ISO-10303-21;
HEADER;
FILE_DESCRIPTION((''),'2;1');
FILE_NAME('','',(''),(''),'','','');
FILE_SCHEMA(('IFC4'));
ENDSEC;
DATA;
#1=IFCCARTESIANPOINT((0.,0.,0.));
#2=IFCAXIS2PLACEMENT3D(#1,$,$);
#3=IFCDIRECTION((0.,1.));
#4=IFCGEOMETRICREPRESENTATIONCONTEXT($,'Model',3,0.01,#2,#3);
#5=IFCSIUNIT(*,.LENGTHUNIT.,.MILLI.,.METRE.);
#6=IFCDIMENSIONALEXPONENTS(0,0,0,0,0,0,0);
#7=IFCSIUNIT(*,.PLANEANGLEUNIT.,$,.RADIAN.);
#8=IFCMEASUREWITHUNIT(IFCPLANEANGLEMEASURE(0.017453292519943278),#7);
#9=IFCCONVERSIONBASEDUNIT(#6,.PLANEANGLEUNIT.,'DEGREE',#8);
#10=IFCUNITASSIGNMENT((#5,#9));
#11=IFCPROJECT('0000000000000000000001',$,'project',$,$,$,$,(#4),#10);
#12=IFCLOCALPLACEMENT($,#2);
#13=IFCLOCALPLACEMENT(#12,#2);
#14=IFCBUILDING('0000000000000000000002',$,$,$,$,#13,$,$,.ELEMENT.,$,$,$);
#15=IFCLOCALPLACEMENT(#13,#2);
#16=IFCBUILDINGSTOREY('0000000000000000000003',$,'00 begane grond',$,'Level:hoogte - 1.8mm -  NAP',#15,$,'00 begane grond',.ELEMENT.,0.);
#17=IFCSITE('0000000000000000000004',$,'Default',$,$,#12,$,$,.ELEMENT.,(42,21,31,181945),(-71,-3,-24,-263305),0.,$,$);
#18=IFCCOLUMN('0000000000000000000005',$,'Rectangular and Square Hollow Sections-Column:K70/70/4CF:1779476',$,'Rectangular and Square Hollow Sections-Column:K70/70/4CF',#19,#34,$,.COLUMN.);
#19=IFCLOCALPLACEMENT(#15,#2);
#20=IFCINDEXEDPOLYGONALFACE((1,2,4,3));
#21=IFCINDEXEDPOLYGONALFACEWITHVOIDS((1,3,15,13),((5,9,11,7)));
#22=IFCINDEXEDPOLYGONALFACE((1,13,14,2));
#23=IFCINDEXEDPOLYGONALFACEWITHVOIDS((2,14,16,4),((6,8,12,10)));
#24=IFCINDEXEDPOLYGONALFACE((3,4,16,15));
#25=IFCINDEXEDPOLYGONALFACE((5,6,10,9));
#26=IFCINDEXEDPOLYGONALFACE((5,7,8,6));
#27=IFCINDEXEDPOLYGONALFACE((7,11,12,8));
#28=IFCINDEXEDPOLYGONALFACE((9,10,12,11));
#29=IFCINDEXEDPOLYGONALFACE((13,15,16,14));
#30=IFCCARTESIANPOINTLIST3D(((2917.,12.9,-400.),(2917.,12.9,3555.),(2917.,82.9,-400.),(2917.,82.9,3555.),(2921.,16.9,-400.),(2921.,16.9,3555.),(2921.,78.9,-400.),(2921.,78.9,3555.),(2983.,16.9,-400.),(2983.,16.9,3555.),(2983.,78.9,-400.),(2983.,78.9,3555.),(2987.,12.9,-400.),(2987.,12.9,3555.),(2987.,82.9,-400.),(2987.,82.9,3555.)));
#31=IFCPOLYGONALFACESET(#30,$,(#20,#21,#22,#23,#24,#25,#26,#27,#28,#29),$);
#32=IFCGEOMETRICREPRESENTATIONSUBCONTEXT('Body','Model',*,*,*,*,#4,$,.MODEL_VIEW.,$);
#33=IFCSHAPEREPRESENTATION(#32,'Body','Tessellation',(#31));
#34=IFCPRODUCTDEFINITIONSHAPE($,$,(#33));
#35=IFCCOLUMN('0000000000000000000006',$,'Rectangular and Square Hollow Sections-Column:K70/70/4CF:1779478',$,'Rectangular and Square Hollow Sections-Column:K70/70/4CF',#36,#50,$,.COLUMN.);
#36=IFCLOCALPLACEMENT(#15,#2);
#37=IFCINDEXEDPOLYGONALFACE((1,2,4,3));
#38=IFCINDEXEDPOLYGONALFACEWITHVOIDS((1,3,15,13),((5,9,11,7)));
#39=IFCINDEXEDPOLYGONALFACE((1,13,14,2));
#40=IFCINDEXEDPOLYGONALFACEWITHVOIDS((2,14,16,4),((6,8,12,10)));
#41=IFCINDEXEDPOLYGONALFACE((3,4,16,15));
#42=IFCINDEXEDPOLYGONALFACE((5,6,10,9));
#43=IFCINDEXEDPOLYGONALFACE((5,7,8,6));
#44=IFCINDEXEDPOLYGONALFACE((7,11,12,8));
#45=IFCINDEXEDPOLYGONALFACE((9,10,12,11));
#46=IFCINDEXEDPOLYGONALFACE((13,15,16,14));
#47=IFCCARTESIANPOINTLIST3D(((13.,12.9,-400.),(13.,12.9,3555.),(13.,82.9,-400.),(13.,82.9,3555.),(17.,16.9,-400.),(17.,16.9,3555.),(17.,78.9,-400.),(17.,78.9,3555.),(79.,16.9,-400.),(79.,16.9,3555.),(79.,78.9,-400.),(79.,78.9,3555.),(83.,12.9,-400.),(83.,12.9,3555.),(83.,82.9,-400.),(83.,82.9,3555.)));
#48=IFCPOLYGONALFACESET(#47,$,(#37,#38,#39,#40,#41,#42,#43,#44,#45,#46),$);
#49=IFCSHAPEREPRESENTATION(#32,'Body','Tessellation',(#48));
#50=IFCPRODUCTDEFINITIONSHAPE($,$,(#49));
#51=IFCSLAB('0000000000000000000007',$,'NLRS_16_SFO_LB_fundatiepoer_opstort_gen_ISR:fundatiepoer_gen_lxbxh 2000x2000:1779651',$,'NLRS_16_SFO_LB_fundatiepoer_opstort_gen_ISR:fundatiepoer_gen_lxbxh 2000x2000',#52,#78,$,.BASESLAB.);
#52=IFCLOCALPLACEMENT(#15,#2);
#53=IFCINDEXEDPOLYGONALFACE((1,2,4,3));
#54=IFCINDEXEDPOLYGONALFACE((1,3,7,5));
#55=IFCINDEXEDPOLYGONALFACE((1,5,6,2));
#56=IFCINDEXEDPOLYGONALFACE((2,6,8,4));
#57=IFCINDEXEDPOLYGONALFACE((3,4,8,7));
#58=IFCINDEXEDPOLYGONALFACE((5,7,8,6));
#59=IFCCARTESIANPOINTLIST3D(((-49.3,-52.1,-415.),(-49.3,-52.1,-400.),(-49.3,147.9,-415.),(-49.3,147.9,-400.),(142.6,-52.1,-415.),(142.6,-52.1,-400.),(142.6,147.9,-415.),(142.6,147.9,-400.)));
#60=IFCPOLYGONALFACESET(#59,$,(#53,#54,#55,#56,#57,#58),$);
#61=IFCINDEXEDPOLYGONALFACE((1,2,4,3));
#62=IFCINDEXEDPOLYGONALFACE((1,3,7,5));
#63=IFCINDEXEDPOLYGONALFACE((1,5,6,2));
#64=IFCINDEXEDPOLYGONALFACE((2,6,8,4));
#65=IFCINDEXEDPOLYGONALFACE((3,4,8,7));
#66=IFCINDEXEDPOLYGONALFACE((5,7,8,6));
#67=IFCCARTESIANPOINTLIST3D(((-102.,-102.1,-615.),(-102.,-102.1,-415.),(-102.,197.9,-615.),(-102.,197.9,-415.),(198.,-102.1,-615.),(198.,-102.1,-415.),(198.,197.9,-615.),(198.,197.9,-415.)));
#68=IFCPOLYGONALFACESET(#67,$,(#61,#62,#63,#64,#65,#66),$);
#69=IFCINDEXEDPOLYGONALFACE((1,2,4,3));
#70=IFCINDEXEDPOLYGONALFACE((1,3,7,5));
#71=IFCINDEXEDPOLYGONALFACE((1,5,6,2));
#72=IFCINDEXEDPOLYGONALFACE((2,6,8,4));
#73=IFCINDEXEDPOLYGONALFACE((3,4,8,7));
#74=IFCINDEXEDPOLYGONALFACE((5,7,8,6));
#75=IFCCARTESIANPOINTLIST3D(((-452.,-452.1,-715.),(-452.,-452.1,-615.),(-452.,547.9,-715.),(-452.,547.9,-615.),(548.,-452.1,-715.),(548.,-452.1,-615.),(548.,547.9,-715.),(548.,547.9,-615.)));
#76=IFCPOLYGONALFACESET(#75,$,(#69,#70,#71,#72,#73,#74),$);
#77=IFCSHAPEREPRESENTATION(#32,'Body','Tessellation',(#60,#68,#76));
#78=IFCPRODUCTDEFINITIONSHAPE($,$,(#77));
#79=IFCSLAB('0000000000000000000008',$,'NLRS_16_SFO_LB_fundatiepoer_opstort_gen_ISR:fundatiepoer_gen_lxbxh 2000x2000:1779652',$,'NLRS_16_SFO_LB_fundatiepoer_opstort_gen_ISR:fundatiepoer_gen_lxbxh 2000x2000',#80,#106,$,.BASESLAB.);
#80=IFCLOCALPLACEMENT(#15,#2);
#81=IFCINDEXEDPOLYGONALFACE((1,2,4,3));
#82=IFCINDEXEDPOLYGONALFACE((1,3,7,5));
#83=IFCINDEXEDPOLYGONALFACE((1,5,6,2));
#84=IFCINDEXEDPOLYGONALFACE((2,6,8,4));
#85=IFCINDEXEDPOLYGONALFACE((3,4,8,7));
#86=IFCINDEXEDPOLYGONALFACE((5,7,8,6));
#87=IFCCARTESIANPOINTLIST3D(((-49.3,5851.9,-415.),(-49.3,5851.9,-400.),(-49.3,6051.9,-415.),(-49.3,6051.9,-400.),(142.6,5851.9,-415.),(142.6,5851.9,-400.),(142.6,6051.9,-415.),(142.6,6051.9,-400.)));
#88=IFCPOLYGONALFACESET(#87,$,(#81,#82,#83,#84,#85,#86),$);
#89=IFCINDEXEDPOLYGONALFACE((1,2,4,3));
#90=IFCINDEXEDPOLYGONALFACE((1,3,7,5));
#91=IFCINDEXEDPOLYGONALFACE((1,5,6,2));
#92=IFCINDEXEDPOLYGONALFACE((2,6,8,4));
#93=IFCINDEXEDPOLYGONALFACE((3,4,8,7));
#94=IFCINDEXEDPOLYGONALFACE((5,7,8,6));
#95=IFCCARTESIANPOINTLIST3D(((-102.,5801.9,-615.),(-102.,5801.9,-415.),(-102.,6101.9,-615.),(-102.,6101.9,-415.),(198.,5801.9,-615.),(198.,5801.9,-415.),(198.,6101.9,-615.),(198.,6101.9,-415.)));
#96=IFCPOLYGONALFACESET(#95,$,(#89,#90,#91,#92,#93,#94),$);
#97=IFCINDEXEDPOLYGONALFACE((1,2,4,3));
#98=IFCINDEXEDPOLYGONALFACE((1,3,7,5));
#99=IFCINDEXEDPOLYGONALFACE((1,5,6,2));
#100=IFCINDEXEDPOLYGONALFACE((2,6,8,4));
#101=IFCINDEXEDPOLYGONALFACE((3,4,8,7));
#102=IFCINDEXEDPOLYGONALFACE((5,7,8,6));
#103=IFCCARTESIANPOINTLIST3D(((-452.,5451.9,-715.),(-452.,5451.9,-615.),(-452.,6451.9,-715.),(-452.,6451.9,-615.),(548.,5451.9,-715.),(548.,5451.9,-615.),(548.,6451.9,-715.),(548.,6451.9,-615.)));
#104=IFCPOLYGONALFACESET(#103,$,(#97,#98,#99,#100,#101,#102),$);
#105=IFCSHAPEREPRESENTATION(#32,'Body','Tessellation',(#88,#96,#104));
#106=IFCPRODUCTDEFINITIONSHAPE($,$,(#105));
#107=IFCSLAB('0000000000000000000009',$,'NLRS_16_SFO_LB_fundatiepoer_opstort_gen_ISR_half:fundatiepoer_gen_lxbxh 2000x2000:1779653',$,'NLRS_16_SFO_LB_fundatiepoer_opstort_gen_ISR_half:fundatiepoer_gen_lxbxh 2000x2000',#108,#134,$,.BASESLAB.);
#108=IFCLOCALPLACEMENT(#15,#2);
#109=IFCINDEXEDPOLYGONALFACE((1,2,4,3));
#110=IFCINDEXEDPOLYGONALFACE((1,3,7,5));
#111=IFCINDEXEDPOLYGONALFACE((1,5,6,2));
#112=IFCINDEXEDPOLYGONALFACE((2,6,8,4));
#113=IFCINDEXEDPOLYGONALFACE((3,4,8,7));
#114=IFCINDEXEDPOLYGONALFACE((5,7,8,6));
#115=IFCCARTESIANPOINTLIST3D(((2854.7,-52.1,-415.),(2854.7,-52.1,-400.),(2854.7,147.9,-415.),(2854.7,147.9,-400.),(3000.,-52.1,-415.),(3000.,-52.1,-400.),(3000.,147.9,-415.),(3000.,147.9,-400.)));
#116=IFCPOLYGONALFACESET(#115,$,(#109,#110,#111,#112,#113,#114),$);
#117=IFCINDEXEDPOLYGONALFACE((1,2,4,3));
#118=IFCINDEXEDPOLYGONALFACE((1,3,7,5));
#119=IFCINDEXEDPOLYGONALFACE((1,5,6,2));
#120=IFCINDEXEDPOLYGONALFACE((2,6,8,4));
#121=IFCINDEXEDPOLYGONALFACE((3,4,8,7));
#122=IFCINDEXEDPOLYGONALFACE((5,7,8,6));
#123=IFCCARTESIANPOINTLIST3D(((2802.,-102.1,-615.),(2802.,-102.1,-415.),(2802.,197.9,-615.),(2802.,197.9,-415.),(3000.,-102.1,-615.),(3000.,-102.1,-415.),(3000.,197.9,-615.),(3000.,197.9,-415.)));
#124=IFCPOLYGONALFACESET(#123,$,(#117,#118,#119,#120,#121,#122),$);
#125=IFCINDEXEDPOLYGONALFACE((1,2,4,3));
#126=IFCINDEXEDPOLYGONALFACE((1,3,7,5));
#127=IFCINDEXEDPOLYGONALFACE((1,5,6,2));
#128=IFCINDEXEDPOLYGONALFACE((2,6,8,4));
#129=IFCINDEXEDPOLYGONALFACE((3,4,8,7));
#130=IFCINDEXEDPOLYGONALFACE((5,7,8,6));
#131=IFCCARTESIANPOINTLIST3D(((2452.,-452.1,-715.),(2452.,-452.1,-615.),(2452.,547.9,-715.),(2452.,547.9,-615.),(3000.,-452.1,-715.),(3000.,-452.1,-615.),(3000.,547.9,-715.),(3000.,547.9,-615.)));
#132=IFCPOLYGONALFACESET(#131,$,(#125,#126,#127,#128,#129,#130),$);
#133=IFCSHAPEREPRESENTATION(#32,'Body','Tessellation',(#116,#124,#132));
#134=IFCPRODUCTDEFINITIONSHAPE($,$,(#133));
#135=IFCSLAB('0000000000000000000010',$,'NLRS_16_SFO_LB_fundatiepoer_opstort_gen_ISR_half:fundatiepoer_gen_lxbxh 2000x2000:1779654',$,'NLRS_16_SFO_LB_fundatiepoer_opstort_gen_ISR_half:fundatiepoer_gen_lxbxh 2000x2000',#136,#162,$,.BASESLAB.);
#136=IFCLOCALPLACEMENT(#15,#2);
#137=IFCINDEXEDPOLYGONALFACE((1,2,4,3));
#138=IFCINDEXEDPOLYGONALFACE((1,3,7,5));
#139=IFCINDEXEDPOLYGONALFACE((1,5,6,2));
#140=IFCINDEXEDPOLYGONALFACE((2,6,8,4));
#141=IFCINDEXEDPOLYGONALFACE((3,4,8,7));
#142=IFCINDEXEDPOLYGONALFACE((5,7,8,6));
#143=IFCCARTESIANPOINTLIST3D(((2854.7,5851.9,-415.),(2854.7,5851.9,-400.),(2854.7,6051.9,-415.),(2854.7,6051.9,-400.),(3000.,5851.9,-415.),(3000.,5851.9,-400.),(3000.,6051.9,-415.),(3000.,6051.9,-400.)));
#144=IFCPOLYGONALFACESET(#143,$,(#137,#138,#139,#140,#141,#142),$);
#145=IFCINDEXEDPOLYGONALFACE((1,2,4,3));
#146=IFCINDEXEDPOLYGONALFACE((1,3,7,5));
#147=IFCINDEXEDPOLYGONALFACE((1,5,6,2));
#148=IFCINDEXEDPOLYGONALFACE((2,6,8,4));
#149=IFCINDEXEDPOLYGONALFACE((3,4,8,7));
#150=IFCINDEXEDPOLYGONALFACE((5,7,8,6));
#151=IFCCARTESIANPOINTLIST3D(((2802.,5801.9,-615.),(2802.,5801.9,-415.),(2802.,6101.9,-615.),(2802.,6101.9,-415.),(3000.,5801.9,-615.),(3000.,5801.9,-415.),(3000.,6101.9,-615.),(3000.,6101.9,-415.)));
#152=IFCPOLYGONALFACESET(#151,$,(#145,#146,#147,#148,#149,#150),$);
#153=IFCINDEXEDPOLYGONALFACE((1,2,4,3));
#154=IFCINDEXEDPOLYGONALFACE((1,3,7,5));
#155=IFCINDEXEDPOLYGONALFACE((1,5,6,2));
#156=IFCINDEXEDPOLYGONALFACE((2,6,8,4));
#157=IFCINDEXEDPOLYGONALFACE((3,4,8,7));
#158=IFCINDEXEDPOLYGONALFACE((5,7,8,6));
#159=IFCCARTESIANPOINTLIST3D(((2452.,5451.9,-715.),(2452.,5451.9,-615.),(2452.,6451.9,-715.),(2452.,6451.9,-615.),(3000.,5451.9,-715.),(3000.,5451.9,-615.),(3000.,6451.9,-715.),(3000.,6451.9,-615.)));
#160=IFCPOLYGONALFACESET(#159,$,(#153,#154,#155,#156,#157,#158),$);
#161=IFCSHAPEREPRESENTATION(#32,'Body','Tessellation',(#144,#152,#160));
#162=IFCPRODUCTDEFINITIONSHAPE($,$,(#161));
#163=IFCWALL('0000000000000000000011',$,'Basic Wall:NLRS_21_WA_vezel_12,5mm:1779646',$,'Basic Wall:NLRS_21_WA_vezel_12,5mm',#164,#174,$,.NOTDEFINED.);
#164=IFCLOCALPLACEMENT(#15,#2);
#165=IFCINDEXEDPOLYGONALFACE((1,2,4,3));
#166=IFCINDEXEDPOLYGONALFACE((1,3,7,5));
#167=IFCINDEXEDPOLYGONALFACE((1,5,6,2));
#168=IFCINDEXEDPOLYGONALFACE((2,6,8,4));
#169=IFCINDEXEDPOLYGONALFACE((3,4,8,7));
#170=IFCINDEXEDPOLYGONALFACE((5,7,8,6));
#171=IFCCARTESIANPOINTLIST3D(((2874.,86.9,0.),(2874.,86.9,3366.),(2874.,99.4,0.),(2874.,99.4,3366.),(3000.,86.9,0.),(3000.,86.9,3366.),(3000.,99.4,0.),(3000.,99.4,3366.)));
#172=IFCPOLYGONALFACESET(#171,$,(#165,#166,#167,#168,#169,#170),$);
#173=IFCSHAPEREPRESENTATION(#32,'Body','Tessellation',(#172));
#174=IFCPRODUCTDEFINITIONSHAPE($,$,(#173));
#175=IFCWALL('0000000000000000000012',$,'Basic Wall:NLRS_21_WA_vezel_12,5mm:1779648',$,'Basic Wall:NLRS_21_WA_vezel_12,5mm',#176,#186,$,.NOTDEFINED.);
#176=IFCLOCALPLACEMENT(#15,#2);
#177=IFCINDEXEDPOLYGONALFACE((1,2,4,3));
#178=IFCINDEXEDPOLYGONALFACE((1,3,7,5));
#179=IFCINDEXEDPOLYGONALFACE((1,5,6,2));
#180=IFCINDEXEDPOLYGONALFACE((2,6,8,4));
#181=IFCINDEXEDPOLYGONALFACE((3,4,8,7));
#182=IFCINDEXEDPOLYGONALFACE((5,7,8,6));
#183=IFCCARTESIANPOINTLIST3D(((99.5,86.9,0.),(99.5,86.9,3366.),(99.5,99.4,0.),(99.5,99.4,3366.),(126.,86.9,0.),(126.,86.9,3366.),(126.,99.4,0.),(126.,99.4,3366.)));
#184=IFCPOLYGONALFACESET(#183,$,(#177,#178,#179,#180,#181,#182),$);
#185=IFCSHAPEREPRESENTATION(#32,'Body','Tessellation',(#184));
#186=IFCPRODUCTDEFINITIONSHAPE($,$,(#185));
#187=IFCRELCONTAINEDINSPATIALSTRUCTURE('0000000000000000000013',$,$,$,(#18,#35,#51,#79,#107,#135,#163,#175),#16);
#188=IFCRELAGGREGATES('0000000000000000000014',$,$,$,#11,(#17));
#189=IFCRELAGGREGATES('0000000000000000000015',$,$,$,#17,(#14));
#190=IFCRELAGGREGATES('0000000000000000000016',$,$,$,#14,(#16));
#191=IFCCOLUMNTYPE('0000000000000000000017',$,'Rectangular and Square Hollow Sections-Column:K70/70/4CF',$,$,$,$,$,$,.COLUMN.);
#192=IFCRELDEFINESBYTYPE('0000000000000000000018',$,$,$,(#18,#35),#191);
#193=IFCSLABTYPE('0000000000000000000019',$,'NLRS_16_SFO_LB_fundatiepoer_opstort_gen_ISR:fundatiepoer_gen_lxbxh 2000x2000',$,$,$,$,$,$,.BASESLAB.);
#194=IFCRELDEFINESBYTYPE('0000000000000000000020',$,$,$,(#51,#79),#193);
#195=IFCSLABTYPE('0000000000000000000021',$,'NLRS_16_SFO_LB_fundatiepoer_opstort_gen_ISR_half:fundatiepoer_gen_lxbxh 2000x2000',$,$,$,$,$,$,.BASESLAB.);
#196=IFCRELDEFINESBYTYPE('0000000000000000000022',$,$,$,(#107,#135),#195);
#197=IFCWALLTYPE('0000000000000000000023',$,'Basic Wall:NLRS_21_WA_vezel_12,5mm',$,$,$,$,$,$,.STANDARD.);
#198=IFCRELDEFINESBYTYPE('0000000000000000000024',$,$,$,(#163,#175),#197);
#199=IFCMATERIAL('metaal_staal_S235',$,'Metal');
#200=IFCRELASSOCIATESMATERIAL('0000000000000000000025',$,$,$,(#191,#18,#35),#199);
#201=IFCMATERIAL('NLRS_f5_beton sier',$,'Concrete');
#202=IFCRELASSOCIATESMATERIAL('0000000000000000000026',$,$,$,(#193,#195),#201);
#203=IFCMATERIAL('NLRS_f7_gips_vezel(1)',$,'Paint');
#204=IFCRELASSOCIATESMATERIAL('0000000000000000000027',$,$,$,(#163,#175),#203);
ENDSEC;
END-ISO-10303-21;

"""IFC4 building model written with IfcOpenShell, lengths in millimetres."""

from ifc_helpers import new_model, entity, si_unit, converted_unit, direction, frame, origin, place, context, subcontext, project, spatial, indexed_curve, outline, extrude, source, transform, mapped, material, type_object, type_shapes, element, save


model = new_model("IFC4")

# Units and contexts
model_context = context("Model", 3, precision=0.01, world=origin(), true_north=direction((0.0, 1.0)))
body_context = subcontext(model_context, "Body", "Model", "MODEL_VIEW")
ifc_project = project(units=[si_unit("LENGTHUNIT", "METRE", prefix="MILLI"), converted_unit("PLANEANGLEUNIT", "DEGREE", entity("IfcPlaneAngleMeasure", 0.017453292519943278), si_unit("PLANEANGLEUNIT", "RADIAN"), dimensions=[0, 0, 0, 0, 0, 0, 0])], contexts=[model_context])

# Site, building, storey
site_placement = place(None, origin())
site = spatial("IfcSite", under=ifc_project, at=site_placement, Name="Default", CompositionType="ELEMENT", RefLatitude=(42, 21, 31, 181945), RefLongitude=(-71, -3, -24, -263305), RefElevation=0.0)
building_placement = place(site_placement, origin())
building = spatial("IfcBuilding", under=site, at=building_placement, CompositionType="ELEMENT")
storey_placement = place(building_placement, origin())
storey = spatial("IfcBuildingStorey", under=building, at=storey_placement, Name="00 begane grond", ObjectType="Level:hoogte - 1.8mm -  NAP", LongName="00 begane grond", CompositionType="ELEMENT", Elevation=0.0)

# Columns
ifc_material_1 = material(Name="metaal_staal_S235", Category="Metal")
column_type = type_object("IfcColumnType", Name="Rectangular and Square Hollow Sections-Column:K70/70/4CF", PredefinedType="COLUMN", material=ifc_material_1)
shared_shape_1 = source(origin(), body_context, "Body", "SweptSolid", [
    extrude(outline(indexed_curve([(-35.0, -35.0), (35.0, -35.0), (35.0, 35.0), (-35.0, 35.0), (-35.0, -35.0)], self_intersect=False), holes=[indexed_curve([(-31.0, -31.0), (-31.0, 31.0), (31.0, 31.0), (31.0, -31.0), (-31.0, -31.0)], self_intersect=False)]), frame((0.0, 0.0, -400.0), z_axis=(0.0, 0.0, 1.0), x_axis=(-1.0, 0.0, 0.0)), (0.0, 0.0, 1.0), 3955.0),
])
type_shapes(column_type, [shared_shape_1])
for number, where, z_axis, x_axis, name in (
    (1, (2952.0, 47.9, 0.0), (0.0, 0.0, 1.0), (0.0, -1.0, 0.0), "Rectangular and Square Hollow Sections-Column:K70/70/4CF:1779476"),
    (2, (48.0, 47.9, 0.0), (0.0, 0.0, 1.0), (0.0, -1.0, 0.0), "Rectangular and Square Hollow Sections-Column:K70/70/4CF:1779478"),
):
    element("IfcColumn", number, at=place(storey_placement, frame(where, z_axis=z_axis, x_axis=x_axis)), inside=storey, type_object=column_type, material=ifc_material_1, Name=name, ObjectType="Rectangular and Square Hollow Sections-Column:K70/70/4CF", PredefinedType="COLUMN", context=body_context, shape_type="MappedRepresentation", body=[
        mapped(shared_shape_1, transform((0.0, 0.0, 0.0), scale=1.0)),
    ])

# Slabs
ifc_material_2 = material(Name="NLRS_f5_beton sier", Category="Concrete")
slab_type_1 = type_object("IfcSlabType", Name="NLRS_16_SFO_LB_fundatiepoer_opstort_gen_ISR:fundatiepoer_gen_lxbxh 2000x2000", PredefinedType="BASESLAB", material=ifc_material_2)
slab_1_placement = place(storey_placement, frame((0.0, 0.0, -615.0)))
element("IfcSlab", 3, at=slab_1_placement, inside=storey, type_object=slab_type_1, Name="NLRS_16_SFO_LB_fundatiepoer_opstort_gen_ISR:fundatiepoer_gen_lxbxh 2000x2000:1779651", ObjectType="NLRS_16_SFO_LB_fundatiepoer_opstort_gen_ISR:fundatiepoer_gen_lxbxh 2000x2000", PredefinedType="BASESLAB", context=body_context, shape_type="SweptSolid", body=[
    extrude(outline(indexed_curve([(-95.9, -100.0), (95.9, -100.0), (95.9, 100.0), (-95.9, 100.0), (-95.9, -100.0)], self_intersect=False)), frame((46.6, 47.9, 200.0), z_axis=(0.0, 0.0, 1.0), x_axis=(-1.0, 0.0, 0.0)), (0.0, 0.0, 1.0), 15.0),
    extrude(outline(indexed_curve([(-150.0, -150.0), (150.0, -150.0), (150.0, 150.0), (-150.0, 150.0), (-150.0, -150.0)], self_intersect=False)), frame((48.0, 47.9, 0.0), z_axis=(0.0, 0.0, 1.0), x_axis=(-1.0, 0.0, 0.0)), (0.0, 0.0, 1.0), 200.0),
    extrude(outline(indexed_curve([(-500.0, -500.0), (500.0, -500.0), (500.0, 500.0), (-500.0, 500.0), (-500.0, -500.0)], self_intersect=False)), frame((48.0, 47.9, -100.0), z_axis=(0.0, 0.0, 1.0), x_axis=(-1.0, 0.0, 0.0)), (0.0, 0.0, 1.0), 100.0),
])
slab_2_placement = place(storey_placement, frame((0.0, 0.0, -615.0)))
element("IfcSlab", 4, at=slab_2_placement, inside=storey, type_object=slab_type_1, Name="NLRS_16_SFO_LB_fundatiepoer_opstort_gen_ISR:fundatiepoer_gen_lxbxh 2000x2000:1779652", ObjectType="NLRS_16_SFO_LB_fundatiepoer_opstort_gen_ISR:fundatiepoer_gen_lxbxh 2000x2000", PredefinedType="BASESLAB", context=body_context, shape_type="SweptSolid", body=[
    extrude(outline(indexed_curve([(-100.0, -95.9), (100.0, -95.9), (100.0, 95.9), (-100.0, 95.9), (-100.0, -95.9)], self_intersect=False)), frame((46.6, 5951.9, 200.0), z_axis=(0.0, 0.0, 1.0), x_axis=(0.0, 1.0, 0.0)), (0.0, 0.0, 1.0), 15.0),
    extrude(outline(indexed_curve([(-150.0, -150.0), (150.0, -150.0), (150.0, 150.0), (-150.0, 150.0), (-150.0, -150.0)], self_intersect=False)), frame((48.0, 5951.9, 0.0), z_axis=(0.0, 0.0, 1.0), x_axis=(0.0, 1.0, 0.0)), (0.0, 0.0, 1.0), 200.0),
    extrude(outline(indexed_curve([(-500.0, -500.0), (500.0, -500.0), (500.0, 500.0), (-500.0, 500.0), (-500.0, -500.0)], self_intersect=False)), frame((48.0, 5951.9, -100.0), z_axis=(0.0, 0.0, 1.0), x_axis=(0.0, 1.0, 0.0)), (0.0, 0.0, 1.0), 100.0),
])
slab_type_2 = type_object("IfcSlabType", Name="NLRS_16_SFO_LB_fundatiepoer_opstort_gen_ISR_half:fundatiepoer_gen_lxbxh 2000x2000", PredefinedType="BASESLAB", material=ifc_material_2)
slab_3_placement = place(storey_placement, frame((0.0, 0.0, -615.0)))
element("IfcSlab", 5, at=slab_3_placement, inside=storey, type_object=slab_type_2, Name="NLRS_16_SFO_LB_fundatiepoer_opstort_gen_ISR_half:fundatiepoer_gen_lxbxh 2000x2000:1779653", ObjectType="NLRS_16_SFO_LB_fundatiepoer_opstort_gen_ISR_half:fundatiepoer_gen_lxbxh 2000x2000", PredefinedType="BASESLAB", context=body_context, shape_type="SweptSolid", body=[
    extrude(outline(indexed_curve([(-72.6, -100.0), (72.6, -100.0), (72.6, 100.0), (-72.6, 100.0), (-72.6, -100.0)], self_intersect=False)), frame((2927.3, 47.9, 200.0)), (0.0, 0.0, 1.0), 15.0),
    extrude(outline(indexed_curve([(-99.0, -150.0), (99.0, -150.0), (99.0, 150.0), (-99.0, 150.0), (-99.0, -150.0)], self_intersect=False)), frame((2901.0, 47.9, 0.0)), (0.0, 0.0, 1.0), 200.0),
    extrude(outline(indexed_curve([(-274.0, -500.0), (274.0, -500.0), (274.0, 500.0), (-274.0, 500.0), (-274.0, -500.0)], self_intersect=False)), frame((2726.0, 47.9, -100.0)), (0.0, 0.0, 1.0), 100.0),
])
slab_4_placement = place(storey_placement, frame((0.0, 0.0, -615.0)))
element("IfcSlab", 6, at=slab_4_placement, inside=storey, type_object=slab_type_2, Name="NLRS_16_SFO_LB_fundatiepoer_opstort_gen_ISR_half:fundatiepoer_gen_lxbxh 2000x2000:1779654", ObjectType="NLRS_16_SFO_LB_fundatiepoer_opstort_gen_ISR_half:fundatiepoer_gen_lxbxh 2000x2000", PredefinedType="BASESLAB", context=body_context, shape_type="SweptSolid", body=[
    extrude(outline(indexed_curve([(-100.0, -72.6), (100.0, -72.6), (100.0, 72.6), (-100.0, 72.6), (-100.0, -72.6)], self_intersect=False)), frame((2927.3, 5951.9, 200.0), z_axis=(0.0, 0.0, 1.0), x_axis=(0.0, -1.0, 0.0)), (0.0, 0.0, 1.0), 15.0),
    extrude(outline(indexed_curve([(-150.0, -99.0), (150.0, -99.0), (150.0, 99.0), (-150.0, 99.0), (-150.0, -99.0)], self_intersect=False)), frame((2901.0, 5951.9, 0.0), z_axis=(0.0, 0.0, 1.0), x_axis=(0.0, -1.0, 0.0)), (0.0, 0.0, 1.0), 200.0),
    extrude(outline(indexed_curve([(-500.0, -274.0), (500.0, -274.0), (500.0, 274.0), (-500.0, 274.0), (-500.0, -274.0)], self_intersect=False)), frame((2726.0, 5951.9, -100.0), z_axis=(0.0, 0.0, 1.0), x_axis=(0.0, -1.0, 0.0)), (0.0, 0.0, 1.0), 100.0),
])

# Walls
ifc_material_3 = material(Name="NLRS_f7_gips_vezel(1)", Category="Paint")
wall_type_1 = type_object("IfcWallType", Name="Basic Wall:NLRS_21_WA_vezel_12,5mm", PredefinedType="STANDARD")
wall_1_placement = place(storey_placement, frame((2874.0, 93.2, 0.0)))
element("IfcWall", 7, at=wall_1_placement, inside=storey, type_object=wall_type_1, material=ifc_material_3, Name="Basic Wall:NLRS_21_WA_vezel_12,5mm:1779646", ObjectType="Basic Wall:NLRS_21_WA_vezel_12,5mm", PredefinedType="NOTDEFINED", context=body_context, shape_type="SweptSolid", body=[
    extrude(outline(indexed_curve([(126.0, 6.2), (0.0, 6.2), (0.0, -6.2), (126.0, -6.2), (126.0, 6.2)], self_intersect=False)), origin(), (0.0, 0.0, 1.0), 3366.0),
])
wall_2_placement = place(storey_placement, frame((99.5, 93.2, 0.0)))
element("IfcWall", 8, at=wall_2_placement, inside=storey, type_object=wall_type_1, material=ifc_material_3, Name="Basic Wall:NLRS_21_WA_vezel_12,5mm:1779648", ObjectType="Basic Wall:NLRS_21_WA_vezel_12,5mm", PredefinedType="NOTDEFINED", context=body_context, shape_type="SweptSolid", body=[
    extrude(outline(indexed_curve([(26.5, 6.2), (0.0, 6.2), (0.0, -6.2), (26.5, -6.3), (26.5, 6.2)], self_intersect=False)), origin(), (0.0, 0.0, 1.0), 3366.0),
])

save(model, "model.ifc")
